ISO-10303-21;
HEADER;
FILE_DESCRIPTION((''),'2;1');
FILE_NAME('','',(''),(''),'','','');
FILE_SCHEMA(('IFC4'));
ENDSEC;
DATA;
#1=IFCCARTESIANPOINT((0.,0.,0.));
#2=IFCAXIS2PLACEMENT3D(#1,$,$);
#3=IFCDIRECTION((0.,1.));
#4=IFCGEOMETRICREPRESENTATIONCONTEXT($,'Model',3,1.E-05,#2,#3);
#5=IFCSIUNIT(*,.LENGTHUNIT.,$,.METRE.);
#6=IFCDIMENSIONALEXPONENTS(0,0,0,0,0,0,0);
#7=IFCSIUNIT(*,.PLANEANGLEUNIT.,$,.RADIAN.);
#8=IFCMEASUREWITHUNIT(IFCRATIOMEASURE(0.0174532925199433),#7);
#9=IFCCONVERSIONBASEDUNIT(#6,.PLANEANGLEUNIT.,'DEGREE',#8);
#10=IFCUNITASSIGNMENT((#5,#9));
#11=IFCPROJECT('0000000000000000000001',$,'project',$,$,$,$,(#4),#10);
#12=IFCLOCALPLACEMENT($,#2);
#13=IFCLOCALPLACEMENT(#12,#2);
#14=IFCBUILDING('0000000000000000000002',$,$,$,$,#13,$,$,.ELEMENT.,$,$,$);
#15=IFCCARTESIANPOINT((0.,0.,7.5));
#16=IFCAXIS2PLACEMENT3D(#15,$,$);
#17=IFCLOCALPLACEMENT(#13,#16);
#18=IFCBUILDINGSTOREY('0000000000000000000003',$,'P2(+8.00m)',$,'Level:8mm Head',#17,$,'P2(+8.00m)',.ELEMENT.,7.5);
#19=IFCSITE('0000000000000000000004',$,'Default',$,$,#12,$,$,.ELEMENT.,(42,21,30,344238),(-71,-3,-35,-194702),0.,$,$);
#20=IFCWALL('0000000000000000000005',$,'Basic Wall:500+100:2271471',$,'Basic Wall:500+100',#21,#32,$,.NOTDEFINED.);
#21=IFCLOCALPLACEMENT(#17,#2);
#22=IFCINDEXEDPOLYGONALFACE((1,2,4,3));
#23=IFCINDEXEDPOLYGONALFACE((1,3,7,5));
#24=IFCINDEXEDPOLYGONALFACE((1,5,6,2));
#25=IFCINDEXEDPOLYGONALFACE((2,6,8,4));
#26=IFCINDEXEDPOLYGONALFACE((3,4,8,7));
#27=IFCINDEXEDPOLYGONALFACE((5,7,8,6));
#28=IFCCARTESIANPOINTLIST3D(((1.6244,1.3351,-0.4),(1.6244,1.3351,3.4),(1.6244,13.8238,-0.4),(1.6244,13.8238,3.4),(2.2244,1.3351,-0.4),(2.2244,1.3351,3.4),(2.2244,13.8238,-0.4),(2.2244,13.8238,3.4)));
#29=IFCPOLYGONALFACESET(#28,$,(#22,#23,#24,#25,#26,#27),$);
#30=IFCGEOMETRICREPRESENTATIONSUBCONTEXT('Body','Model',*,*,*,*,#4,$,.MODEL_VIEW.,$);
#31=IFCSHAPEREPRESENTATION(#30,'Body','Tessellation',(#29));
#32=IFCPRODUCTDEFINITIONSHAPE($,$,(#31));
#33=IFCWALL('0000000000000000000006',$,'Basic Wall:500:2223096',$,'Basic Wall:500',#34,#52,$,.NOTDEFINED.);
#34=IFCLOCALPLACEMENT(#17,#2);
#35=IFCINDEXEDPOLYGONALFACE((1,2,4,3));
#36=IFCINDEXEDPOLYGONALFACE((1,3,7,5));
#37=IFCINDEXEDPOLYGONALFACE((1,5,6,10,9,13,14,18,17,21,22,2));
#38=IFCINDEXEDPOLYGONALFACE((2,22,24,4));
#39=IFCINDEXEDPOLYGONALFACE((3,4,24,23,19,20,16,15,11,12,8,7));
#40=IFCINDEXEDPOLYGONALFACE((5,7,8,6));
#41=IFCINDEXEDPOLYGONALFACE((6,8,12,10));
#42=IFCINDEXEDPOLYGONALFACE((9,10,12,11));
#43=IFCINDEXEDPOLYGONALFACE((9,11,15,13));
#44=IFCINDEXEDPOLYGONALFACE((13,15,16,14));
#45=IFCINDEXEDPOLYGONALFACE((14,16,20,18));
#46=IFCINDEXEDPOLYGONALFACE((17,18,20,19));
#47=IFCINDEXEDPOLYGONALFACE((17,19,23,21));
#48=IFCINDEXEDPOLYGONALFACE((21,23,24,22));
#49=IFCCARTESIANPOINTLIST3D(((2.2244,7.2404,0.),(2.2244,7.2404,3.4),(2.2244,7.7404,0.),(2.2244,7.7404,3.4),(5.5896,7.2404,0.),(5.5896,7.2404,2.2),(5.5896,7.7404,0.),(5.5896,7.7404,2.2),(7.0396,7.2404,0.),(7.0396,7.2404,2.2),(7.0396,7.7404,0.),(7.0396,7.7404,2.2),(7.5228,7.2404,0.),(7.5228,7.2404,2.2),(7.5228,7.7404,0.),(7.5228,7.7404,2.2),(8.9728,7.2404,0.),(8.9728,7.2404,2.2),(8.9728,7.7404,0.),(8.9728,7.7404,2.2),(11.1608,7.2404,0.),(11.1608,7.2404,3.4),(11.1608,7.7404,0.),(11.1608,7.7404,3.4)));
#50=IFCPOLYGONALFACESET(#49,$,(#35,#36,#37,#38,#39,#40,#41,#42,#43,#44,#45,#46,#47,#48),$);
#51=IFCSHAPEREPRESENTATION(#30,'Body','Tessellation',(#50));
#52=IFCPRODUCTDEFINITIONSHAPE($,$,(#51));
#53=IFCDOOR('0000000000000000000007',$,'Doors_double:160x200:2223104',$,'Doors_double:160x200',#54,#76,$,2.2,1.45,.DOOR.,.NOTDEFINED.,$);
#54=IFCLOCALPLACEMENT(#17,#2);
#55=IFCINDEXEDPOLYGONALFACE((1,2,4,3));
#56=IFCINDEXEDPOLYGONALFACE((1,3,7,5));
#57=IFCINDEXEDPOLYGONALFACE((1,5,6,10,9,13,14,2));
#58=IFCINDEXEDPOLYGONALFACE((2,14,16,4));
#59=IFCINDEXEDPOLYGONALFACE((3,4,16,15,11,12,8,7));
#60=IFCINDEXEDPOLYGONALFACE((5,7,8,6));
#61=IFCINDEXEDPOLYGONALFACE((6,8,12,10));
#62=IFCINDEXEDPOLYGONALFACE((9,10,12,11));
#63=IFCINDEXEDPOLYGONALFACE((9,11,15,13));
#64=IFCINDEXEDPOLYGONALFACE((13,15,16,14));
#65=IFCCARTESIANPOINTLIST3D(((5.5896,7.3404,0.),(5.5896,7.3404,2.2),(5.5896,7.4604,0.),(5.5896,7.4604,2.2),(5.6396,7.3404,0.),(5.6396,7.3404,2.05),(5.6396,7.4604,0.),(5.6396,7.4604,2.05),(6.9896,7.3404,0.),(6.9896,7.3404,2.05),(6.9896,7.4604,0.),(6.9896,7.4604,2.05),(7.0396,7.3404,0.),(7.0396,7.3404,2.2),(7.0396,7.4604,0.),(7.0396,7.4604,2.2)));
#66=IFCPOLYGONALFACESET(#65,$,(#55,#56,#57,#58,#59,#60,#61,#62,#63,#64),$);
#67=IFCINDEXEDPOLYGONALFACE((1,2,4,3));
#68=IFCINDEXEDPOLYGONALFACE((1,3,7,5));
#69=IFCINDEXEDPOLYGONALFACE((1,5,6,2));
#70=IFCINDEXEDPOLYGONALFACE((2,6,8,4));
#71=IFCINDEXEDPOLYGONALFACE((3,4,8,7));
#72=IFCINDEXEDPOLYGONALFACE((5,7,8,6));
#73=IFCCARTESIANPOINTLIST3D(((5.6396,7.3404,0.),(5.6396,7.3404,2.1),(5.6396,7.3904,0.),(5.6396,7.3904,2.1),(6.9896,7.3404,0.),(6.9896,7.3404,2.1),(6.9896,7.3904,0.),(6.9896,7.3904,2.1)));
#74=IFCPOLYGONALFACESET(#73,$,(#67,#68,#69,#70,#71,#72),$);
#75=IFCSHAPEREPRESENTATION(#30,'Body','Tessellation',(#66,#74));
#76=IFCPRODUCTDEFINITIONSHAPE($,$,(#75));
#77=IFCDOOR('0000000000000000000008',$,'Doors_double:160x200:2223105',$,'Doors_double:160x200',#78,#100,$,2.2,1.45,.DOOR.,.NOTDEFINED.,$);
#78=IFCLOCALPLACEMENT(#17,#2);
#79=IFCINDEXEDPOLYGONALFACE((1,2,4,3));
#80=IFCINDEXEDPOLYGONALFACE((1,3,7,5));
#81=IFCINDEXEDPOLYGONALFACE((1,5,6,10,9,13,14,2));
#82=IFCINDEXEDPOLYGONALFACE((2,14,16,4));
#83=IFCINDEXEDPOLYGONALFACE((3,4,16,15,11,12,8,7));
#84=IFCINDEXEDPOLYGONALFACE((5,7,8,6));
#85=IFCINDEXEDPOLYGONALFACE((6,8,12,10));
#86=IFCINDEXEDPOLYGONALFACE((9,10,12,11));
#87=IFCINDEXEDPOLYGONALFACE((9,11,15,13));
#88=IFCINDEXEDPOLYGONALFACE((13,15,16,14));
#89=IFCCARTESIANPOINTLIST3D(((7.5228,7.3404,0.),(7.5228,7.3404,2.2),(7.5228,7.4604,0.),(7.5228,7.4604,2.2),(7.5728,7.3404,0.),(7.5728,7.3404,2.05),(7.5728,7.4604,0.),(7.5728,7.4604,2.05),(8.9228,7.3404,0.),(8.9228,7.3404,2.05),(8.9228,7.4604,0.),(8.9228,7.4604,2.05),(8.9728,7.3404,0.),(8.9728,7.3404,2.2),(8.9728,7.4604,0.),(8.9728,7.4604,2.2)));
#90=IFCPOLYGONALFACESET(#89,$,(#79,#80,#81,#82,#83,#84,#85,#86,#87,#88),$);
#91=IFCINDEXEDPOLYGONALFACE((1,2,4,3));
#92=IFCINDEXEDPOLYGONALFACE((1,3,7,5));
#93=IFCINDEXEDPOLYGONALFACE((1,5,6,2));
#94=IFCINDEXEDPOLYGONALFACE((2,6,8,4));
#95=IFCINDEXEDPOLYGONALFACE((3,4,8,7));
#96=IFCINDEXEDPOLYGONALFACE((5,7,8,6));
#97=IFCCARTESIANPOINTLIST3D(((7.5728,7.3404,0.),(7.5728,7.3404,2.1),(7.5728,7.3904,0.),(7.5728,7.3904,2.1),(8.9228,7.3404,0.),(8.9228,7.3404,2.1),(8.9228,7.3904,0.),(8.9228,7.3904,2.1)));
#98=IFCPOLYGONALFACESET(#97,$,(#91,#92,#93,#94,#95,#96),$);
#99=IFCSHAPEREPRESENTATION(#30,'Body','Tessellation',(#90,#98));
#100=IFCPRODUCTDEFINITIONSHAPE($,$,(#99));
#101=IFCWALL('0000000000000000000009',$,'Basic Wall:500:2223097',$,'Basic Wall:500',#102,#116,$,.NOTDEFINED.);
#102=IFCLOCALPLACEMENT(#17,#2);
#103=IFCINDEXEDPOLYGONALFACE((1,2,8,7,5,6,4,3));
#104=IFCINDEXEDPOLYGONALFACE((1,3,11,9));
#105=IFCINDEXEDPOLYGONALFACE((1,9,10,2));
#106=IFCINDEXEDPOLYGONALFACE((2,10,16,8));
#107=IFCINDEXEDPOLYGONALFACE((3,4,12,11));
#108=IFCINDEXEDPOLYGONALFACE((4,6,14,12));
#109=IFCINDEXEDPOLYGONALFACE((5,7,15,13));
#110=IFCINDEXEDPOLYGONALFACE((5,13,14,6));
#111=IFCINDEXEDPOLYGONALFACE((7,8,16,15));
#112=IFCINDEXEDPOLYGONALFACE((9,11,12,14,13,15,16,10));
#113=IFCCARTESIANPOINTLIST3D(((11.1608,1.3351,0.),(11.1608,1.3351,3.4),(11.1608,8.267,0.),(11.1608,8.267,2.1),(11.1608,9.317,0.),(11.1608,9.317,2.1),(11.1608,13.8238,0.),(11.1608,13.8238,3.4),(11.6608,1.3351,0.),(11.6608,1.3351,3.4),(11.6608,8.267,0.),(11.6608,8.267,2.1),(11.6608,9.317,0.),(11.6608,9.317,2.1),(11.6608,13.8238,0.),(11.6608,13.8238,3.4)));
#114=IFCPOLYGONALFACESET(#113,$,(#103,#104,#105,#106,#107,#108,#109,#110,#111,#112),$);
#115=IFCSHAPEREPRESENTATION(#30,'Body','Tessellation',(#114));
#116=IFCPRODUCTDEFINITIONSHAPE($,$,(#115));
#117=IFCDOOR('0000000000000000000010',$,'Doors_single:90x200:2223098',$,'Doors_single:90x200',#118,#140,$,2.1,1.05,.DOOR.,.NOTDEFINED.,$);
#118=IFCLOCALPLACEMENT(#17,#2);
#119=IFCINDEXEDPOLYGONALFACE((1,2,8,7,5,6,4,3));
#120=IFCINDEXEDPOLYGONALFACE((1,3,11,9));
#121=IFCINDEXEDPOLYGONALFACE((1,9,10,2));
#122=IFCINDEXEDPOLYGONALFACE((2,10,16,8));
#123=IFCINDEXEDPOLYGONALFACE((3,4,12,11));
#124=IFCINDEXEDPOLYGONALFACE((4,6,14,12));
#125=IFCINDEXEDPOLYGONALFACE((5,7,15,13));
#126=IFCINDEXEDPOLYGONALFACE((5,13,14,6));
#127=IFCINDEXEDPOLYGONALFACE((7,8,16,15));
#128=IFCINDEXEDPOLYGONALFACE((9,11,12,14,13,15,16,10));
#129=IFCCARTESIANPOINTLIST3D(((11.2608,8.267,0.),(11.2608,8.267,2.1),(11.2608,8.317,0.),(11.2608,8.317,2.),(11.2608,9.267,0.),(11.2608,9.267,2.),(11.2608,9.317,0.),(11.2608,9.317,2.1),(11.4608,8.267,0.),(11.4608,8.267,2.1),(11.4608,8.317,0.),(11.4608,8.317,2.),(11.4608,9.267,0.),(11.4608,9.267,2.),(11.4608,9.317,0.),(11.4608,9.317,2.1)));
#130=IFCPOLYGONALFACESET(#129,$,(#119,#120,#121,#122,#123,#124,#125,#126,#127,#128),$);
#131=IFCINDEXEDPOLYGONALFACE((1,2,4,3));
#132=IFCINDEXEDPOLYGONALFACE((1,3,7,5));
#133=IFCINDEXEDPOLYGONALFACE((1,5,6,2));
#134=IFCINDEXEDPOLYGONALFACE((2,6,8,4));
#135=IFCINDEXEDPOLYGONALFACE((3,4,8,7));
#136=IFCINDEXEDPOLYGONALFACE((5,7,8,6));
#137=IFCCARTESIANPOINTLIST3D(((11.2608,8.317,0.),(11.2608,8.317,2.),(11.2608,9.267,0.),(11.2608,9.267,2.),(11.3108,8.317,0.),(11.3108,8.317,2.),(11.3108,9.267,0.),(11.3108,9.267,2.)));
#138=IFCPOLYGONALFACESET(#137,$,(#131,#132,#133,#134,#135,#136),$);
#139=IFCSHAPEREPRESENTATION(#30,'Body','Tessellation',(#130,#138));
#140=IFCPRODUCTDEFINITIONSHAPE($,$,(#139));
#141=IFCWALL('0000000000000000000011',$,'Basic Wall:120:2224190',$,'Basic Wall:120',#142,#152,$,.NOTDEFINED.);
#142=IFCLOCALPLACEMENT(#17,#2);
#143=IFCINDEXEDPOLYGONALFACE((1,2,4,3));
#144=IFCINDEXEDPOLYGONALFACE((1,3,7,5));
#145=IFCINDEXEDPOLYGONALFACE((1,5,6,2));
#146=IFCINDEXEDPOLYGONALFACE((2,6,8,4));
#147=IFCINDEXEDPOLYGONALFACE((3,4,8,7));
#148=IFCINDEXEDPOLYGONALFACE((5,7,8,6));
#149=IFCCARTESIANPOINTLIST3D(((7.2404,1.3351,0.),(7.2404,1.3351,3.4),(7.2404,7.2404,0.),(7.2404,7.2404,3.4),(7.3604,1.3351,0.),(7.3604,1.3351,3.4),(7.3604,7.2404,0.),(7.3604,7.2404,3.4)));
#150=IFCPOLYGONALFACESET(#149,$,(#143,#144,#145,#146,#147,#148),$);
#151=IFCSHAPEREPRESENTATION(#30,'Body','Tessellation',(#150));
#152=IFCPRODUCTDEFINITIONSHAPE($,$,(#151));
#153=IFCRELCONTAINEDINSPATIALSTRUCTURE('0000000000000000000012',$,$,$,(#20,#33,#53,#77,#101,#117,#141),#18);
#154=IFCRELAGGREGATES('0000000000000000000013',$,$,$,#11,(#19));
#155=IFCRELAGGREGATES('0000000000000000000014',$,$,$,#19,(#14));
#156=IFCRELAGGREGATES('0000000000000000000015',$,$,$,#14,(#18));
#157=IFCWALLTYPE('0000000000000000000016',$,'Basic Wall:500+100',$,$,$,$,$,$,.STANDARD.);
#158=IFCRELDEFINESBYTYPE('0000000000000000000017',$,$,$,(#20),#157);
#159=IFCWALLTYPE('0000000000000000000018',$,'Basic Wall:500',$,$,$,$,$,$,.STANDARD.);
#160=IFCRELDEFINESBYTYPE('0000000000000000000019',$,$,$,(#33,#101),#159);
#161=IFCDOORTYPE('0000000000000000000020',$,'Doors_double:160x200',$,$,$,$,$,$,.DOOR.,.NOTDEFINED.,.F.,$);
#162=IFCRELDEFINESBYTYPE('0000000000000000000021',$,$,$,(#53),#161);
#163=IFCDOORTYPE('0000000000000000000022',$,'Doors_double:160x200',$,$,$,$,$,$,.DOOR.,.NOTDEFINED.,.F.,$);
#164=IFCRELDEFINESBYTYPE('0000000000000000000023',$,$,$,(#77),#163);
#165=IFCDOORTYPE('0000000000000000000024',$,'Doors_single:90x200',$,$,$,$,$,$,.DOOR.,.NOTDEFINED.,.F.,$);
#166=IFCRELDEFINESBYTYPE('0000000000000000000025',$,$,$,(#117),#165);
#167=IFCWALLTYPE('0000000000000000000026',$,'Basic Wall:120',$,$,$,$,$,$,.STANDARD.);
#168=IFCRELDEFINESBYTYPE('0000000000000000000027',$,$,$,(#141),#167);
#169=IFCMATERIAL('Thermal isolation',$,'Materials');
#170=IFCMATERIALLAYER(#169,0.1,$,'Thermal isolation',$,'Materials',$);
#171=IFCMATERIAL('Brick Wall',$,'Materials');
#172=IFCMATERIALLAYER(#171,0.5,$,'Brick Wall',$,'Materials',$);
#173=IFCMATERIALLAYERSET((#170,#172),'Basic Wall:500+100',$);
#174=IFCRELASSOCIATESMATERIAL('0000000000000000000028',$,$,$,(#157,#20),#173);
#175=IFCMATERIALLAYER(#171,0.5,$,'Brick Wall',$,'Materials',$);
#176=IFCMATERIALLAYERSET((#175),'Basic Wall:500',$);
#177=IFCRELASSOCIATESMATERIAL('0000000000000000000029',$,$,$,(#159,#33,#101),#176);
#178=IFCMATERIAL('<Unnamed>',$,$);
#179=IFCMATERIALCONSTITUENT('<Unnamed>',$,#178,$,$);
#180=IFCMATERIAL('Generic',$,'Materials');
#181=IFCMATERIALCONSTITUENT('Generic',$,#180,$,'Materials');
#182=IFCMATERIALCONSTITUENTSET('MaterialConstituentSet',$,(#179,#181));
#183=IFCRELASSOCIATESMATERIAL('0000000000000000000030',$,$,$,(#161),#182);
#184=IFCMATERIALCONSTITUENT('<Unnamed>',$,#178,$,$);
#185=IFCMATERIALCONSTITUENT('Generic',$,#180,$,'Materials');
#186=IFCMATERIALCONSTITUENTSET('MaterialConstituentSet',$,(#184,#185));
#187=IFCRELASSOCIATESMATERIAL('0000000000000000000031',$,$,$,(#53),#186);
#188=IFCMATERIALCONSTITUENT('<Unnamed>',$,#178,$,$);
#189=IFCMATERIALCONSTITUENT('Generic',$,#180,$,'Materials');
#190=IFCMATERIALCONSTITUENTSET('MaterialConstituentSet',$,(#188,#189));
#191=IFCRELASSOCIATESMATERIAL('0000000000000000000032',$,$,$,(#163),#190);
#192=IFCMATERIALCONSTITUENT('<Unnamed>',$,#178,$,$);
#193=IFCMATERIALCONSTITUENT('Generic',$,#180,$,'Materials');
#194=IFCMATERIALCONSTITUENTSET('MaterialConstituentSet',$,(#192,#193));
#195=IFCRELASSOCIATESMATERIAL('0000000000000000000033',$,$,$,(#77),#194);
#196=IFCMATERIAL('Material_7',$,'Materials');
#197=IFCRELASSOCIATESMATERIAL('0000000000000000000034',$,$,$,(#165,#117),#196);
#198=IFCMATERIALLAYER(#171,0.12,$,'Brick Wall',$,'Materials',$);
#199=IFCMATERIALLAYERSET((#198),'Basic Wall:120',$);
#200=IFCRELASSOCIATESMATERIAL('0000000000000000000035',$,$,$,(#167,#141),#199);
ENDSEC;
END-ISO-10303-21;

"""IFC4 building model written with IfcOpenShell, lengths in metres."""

from ifc_helpers import new_model, entity, si_unit, converted_unit, direction, frame, frame_2d, origin, origin_2d_with_axis, place, context, subcontext, project, spatial, polyline, rectangle, outline, extrude, source, transform, mapped, material, layer, layer_set, layer_usage, constituent, constituent_set, type_object, type_shapes, element, fill, save


model = new_model("IFC4")

# Units and contexts
model_context = context("Model", 3, precision=1e-05, world=origin(), true_north=direction((0.0, 1.0)))
body_context = subcontext(model_context, "Body", "Model", "MODEL_VIEW")
ifc_project = project(units=[si_unit("LENGTHUNIT", "METRE"), converted_unit("PLANEANGLEUNIT", "DEGREE", entity("IfcRatioMeasure", 0.0174532925199433), si_unit("PLANEANGLEUNIT", "RADIAN"), dimensions=[0, 0, 0, 0, 0, 0, 0])], contexts=[model_context])

# Site, building, storey
site_placement = place(None, origin())
site = spatial("IfcSite", under=ifc_project, at=site_placement, Name="Default", CompositionType="ELEMENT", RefLatitude=(42, 21, 30, 344238), RefLongitude=(-71, -3, -35, -194702), RefElevation=0.0)
building_placement = place(site_placement, origin())
building = spatial("IfcBuilding", under=site, at=building_placement, CompositionType="ELEMENT")
storey_placement = place(building_placement, frame((0.0, 0.0, 7.5)))
storey = spatial("IfcBuildingStorey", under=building, at=storey_placement, Name="P2(+8.00m)", ObjectType="Level:8mm Head", LongName="P2(+8.00m)", CompositionType="ELEMENT", Elevation=7.5)

# Wall
ifc_material_1 = material(Name="Thermal isolation", Category="Materials")
ifc_layer_1 = layer(ifc_material_1, 0.1, Name="Thermal isolation", Category="Materials")
ifc_material_2 = material(Name="Brick Wall", Category="Materials")
ifc_layer_2 = layer(ifc_material_2, 0.5, Name="Brick Wall", Category="Materials")
ifc_layer_set_1 = layer_set([ifc_layer_1, ifc_layer_2], Name="Basic Wall:500+100")
ifc_layer_usage_1 = layer_usage(ifc_layer_set_1, "AXIS2", "NEGATIVE", 0.3)
wall_type_1 = type_object("IfcWallType", Name="Basic Wall:500+100", PredefinedType="STANDARD", material=ifc_layer_set_1)
wall_1_placement = place(storey_placement, frame((1.9244, 1.3351, -0.4), z_axis=(0.0, 0.0, 1.0), x_axis=(0.0, 1.0, 0.0)))
element("IfcWall", 1, at=wall_1_placement, inside=storey, type_object=wall_type_1, material=ifc_layer_usage_1, Name="Basic Wall:500+100:2271471", ObjectType="Basic Wall:500+100", PredefinedType="NOTDEFINED", context=body_context, shape_type="SweptSolid", body=[
    extrude(rectangle(XDim=12.4888, YDim=0.6, at=frame_2d((6.2444, 0.0), x_axis=(-1.0, 0.0))), origin(), (0.0, 0.0, 1.0), 3.8),
])

# Wall, openings, doors
ifc_layer_3 = layer(ifc_material_2, 0.5, Name="Brick Wall", Category="Materials")
ifc_layer_set_2 = layer_set([ifc_layer_3], Name="Basic Wall:500")
ifc_layer_usage_2 = layer_usage(ifc_layer_set_2, "AXIS2", "POSITIVE", -0.25)
wall_type_2 = type_object("IfcWallType", Name="Basic Wall:500", PredefinedType="STANDARD", material=ifc_layer_set_2)
wall_2_placement = place(storey_placement, frame((11.1608, 7.4904, 0.0), z_axis=(0.0, 0.0, 1.0), x_axis=(-1.0, 0.0, 0.0)))
wall_2 = element("IfcWall", 2, at=wall_2_placement, inside=storey, type_object=wall_type_2, material=ifc_layer_usage_2, Name="Basic Wall:500:2223096", ObjectType="Basic Wall:500", PredefinedType="NOTDEFINED", context=body_context, shape_type="SweptSolid", body=[
    extrude(rectangle(XDim=8.9364, YDim=0.5, at=frame_2d((4.4682, 0.0), x_axis=(-1.0, 0.0))), origin(), (0.0, 0.0, 1.0), 3.4),
])
opening_1_placement = place(wall_2_placement, frame((2.188, -0.25, 0.0)))
opening_1 = element("IfcOpeningElement", 3, at=opening_1_placement, cuts=wall_2, PredefinedType="OPENING", context=body_context, shape_type="SweptSolid", body=[
    extrude(rectangle(XDim=2.2, YDim=1.45, at=frame_2d((1.1, 0.725), x_axis=(-1.0, 0.0))), frame((0.0, 0.0, 0.0), z_axis=(0.0, 1.0, 0.0), x_axis=(0.0, 0.0, 1.0)), (0.0, 0.0, 1.0), 0.5),
])
opening_2_placement = place(wall_2_placement, frame((4.1212, -0.25, 0.0)))
opening_2 = element("IfcOpeningElement", 4, at=opening_2_placement, cuts=wall_2, PredefinedType="OPENING", context=body_context, shape_type="SweptSolid", body=[
    extrude(rectangle(XDim=2.2, YDim=1.45, at=frame_2d((1.1, 0.725), x_axis=(-1.0, 0.0))), frame((0.0, 0.0, 0.0), z_axis=(0.0, 1.0, 0.0), x_axis=(0.0, 0.0, 1.0)), (0.0, 0.0, 1.0), 0.5),
])
ifc_material_3 = material(Name="<Unnamed>")
ifc_constituent_1 = constituent(ifc_material_3, Name="<Unnamed>")
ifc_material_4 = material(Name="Generic", Category="Materials")
ifc_constituent_2 = constituent(ifc_material_4, Name="Generic", Category="Materials")
ifc_constituent_set_1 = constituent_set(constituents=[ifc_constituent_1, ifc_constituent_2], Name="MaterialConstituentSet")
ifc_constituent_3 = constituent(ifc_material_3, Name="<Unnamed>")
ifc_constituent_4 = constituent(ifc_material_4, Name="Generic", Category="Materials")
ifc_constituent_set_2 = constituent_set(constituents=[ifc_constituent_3, ifc_constituent_4], Name="MaterialConstituentSet")
door_type_1 = type_object("IfcDoorType", Name="Doors_double:160x200", OperationType="NOTDEFINED", ParameterTakesPrecedence=False, PredefinedType="DOOR", material=ifc_constituent_set_2)
shared_shape_1 = source(origin(), body_context, "Body", "SweptSolid", [
    extrude(outline(polyline([(-0.725, -1.0625), (-0.675, -1.0625), (-0.675, 0.9875), (0.675, 0.9875), (0.675, -1.0625), (0.725, -1.0625), (0.725, 1.1375), (-0.725, 1.1375), (-0.725, -1.0625)])), frame((0.725, 0.28, 1.0625), z_axis=(0.0, 1.0, 0.0), x_axis=(-1.0, 0.0, 0.0)), (0.0, 0.0, 1.0), 0.12),
    extrude(rectangle(XDim=1.35, YDim=0.05, at=frame_2d((0.0, 0.0), x_axis=(1.0, 0.0))), frame((0.725, 0.375, 0.0), z_axis=(0.0, 0.0, 1.0), x_axis=(-1.0, 0.0, 0.0)), (0.0, 0.0, 1.0), 2.1),
])
type_shapes(door_type_1, [shared_shape_1])
door_1_placement = place(opening_2_placement, origin())
door_1 = element("IfcDoor", 5, at=door_1_placement, inside=storey, type_object=door_type_1, material=ifc_constituent_set_1, Name="Doors_double:160x200:2223104", ObjectType="Doors_double:160x200", OperationType="NOTDEFINED", OverallHeight=2.2, OverallWidth=1.45, PredefinedType="DOOR", context=body_context, shape_type="MappedRepresentation", body=[
    mapped(shared_shape_1, transform((0.0, 0.0, 0.0), scale=1.0)),
])
fill(opening_2, door_1)
ifc_constituent_5 = constituent(ifc_material_3, Name="<Unnamed>")
ifc_constituent_6 = constituent(ifc_material_4, Name="Generic", Category="Materials")
ifc_constituent_set_3 = constituent_set(constituents=[ifc_constituent_5, ifc_constituent_6], Name="MaterialConstituentSet")
ifc_constituent_7 = constituent(ifc_material_3, Name="<Unnamed>")
ifc_constituent_8 = constituent(ifc_material_4, Name="Generic", Category="Materials")
ifc_constituent_set_4 = constituent_set(constituents=[ifc_constituent_7, ifc_constituent_8], Name="MaterialConstituentSet")
door_type_2 = type_object("IfcDoorType", Name="Doors_double:160x200", OperationType="NOTDEFINED", ParameterTakesPrecedence=False, PredefinedType="DOOR", material=ifc_constituent_set_4)
shared_shape_2 = source(origin(), body_context, "Body", "SweptSolid", [
    extrude(outline(polyline([(-0.725, -1.0625), (-0.675, -1.0625), (-0.675, 0.9875), (0.675, 0.9875), (0.675, -1.0625), (0.725, -1.0625), (0.725, 1.1375), (-0.725, 1.1375), (-0.725, -1.0625)])), frame((1.075, 0.4, 1.0625), z_axis=(0.0, -1.0, 0.0), x_axis=(1.0, 0.0, 0.0)), (0.0, 0.0, 1.0), 0.12),
    extrude(rectangle(XDim=0.05, YDim=1.35, at=origin_2d_with_axis()), frame((1.075, 0.375, 0.0), z_axis=(0.0, 0.0, 1.0), x_axis=(0.0, -1.0, 0.0)), (0.0, 0.0, 1.0), 2.1),
])
type_shapes(door_type_2, [shared_shape_2])
door_2_placement = place(opening_1_placement, frame((-0.35, 0.0, 0.0)))
door_2 = element("IfcDoor", 6, at=door_2_placement, inside=storey, type_object=door_type_2, material=ifc_constituent_set_3, Name="Doors_double:160x200:2223105", ObjectType="Doors_double:160x200", OperationType="NOTDEFINED", OverallHeight=2.2, OverallWidth=1.45, PredefinedType="DOOR", context=body_context, shape_type="MappedRepresentation", body=[
    mapped(shared_shape_2, transform((0.0, 0.0, 0.0), scale=1.0)),
])
fill(opening_1, door_2)

# Wall, opening, door
ifc_layer_usage_3 = layer_usage(ifc_layer_set_2, "AXIS2", "NEGATIVE", 0.25)
wall_3_placement = place(storey_placement, frame((11.4108, 1.3351, 0.0), z_axis=(0.0, 0.0, 1.0), x_axis=(0.0, 1.0, 0.0)))
wall_3 = element("IfcWall", 7, at=wall_3_placement, inside=storey, type_object=wall_type_2, material=ifc_layer_usage_3, Name="Basic Wall:500:2223097", ObjectType="Basic Wall:500", PredefinedType="NOTDEFINED", context=body_context, shape_type="SweptSolid", body=[
    extrude(rectangle(XDim=12.4888, YDim=0.5, at=frame_2d((6.2444, 0.0), x_axis=(-1.0, 0.0))), origin(), (0.0, 0.0, 1.0), 3.4),
])
opening_3_placement = place(wall_3_placement, frame((6.9319, -0.25, 0.0)))
opening_3 = element("IfcOpeningElement", 8, at=opening_3_placement, cuts=wall_3, PredefinedType="OPENING", context=body_context, shape_type="SweptSolid", body=[
    extrude(rectangle(XDim=2.1, YDim=1.05, at=frame_2d((1.05, 0.525), x_axis=(1.0, 0.0))), frame((0.0, 0.0, 0.0), z_axis=(0.0, 1.0, 0.0), x_axis=(0.0, 0.0, 1.0)), (0.0, 0.0, 1.0), 0.5),
])
ifc_material_5 = material(Name="Material_7", Category="Materials")
door_type_3 = type_object("IfcDoorType", Name="Doors_single:90x200", OperationType="NOTDEFINED", ParameterTakesPrecedence=False, PredefinedType="DOOR", material=ifc_material_5)
shared_shape_3 = source(origin(), body_context, "Body", "SweptSolid", [
    extrude(outline(polyline([(-0.525, -1.025), (-0.475, -1.025), (-0.475, 0.975), (0.475, 0.975), (0.475, -1.025), (0.525, -1.025), (0.525, 1.075), (-0.525, 1.075), (-0.525, -1.025)])), frame((0.525, 0.2, 1.025), z_axis=(0.0, 1.0, 0.0), x_axis=(-1.0, 0.0, 0.0)), (0.0, 0.0, 1.0), 0.2),
    extrude(rectangle(XDim=0.95, YDim=0.05, at=origin_2d_with_axis()), frame((0.525, 0.375, 0.0), z_axis=(0.0, 0.0, 1.0), x_axis=(-1.0, 0.0, 0.0)), (0.0, 0.0, 1.0), 2.0),
])
type_shapes(door_type_3, [shared_shape_3])
door_3_placement = place(opening_3_placement, origin())
door_3 = element("IfcDoor", 9, at=door_3_placement, inside=storey, type_object=door_type_3, material=ifc_material_5, Name="Doors_single:90x200:2223098", ObjectType="Doors_single:90x200", OperationType="NOTDEFINED", OverallHeight=2.1, OverallWidth=1.05, PredefinedType="DOOR", context=body_context, shape_type="MappedRepresentation", body=[
    mapped(shared_shape_3, transform((0.0, 0.0, 0.0), scale=1.0)),
])
fill(opening_3, door_3)

# Wall
ifc_layer_4 = layer(ifc_material_2, 0.12, Name="Brick Wall", Category="Materials")
ifc_layer_set_3 = layer_set([ifc_layer_4], Name="Basic Wall:120")
ifc_layer_usage_4 = layer_usage(ifc_layer_set_3, "AXIS2", "POSITIVE", -0.06)
wall_type_3 = type_object("IfcWallType", Name="Basic Wall:120", PredefinedType="STANDARD", material=ifc_layer_set_3)
wall_4_placement = place(storey_placement, frame((7.3004, 7.2404, 0.0), z_axis=(0.0, 0.0, 1.0), x_axis=(0.0, -1.0, 0.0)))
element("IfcWall", 10, at=wall_4_placement, inside=storey, type_object=wall_type_3, material=ifc_layer_usage_4, Name="Basic Wall:120:2224190", ObjectType="Basic Wall:120", PredefinedType="NOTDEFINED", context=body_context, shape_type="SweptSolid", body=[
    extrude(rectangle(XDim=5.9053, YDim=0.12, at=frame_2d((2.9526, 0.0), x_axis=(-1.0, 0.0))), origin(), (0.0, 0.0, 1.0), 3.4),
])

save(model, "model.ifc")
